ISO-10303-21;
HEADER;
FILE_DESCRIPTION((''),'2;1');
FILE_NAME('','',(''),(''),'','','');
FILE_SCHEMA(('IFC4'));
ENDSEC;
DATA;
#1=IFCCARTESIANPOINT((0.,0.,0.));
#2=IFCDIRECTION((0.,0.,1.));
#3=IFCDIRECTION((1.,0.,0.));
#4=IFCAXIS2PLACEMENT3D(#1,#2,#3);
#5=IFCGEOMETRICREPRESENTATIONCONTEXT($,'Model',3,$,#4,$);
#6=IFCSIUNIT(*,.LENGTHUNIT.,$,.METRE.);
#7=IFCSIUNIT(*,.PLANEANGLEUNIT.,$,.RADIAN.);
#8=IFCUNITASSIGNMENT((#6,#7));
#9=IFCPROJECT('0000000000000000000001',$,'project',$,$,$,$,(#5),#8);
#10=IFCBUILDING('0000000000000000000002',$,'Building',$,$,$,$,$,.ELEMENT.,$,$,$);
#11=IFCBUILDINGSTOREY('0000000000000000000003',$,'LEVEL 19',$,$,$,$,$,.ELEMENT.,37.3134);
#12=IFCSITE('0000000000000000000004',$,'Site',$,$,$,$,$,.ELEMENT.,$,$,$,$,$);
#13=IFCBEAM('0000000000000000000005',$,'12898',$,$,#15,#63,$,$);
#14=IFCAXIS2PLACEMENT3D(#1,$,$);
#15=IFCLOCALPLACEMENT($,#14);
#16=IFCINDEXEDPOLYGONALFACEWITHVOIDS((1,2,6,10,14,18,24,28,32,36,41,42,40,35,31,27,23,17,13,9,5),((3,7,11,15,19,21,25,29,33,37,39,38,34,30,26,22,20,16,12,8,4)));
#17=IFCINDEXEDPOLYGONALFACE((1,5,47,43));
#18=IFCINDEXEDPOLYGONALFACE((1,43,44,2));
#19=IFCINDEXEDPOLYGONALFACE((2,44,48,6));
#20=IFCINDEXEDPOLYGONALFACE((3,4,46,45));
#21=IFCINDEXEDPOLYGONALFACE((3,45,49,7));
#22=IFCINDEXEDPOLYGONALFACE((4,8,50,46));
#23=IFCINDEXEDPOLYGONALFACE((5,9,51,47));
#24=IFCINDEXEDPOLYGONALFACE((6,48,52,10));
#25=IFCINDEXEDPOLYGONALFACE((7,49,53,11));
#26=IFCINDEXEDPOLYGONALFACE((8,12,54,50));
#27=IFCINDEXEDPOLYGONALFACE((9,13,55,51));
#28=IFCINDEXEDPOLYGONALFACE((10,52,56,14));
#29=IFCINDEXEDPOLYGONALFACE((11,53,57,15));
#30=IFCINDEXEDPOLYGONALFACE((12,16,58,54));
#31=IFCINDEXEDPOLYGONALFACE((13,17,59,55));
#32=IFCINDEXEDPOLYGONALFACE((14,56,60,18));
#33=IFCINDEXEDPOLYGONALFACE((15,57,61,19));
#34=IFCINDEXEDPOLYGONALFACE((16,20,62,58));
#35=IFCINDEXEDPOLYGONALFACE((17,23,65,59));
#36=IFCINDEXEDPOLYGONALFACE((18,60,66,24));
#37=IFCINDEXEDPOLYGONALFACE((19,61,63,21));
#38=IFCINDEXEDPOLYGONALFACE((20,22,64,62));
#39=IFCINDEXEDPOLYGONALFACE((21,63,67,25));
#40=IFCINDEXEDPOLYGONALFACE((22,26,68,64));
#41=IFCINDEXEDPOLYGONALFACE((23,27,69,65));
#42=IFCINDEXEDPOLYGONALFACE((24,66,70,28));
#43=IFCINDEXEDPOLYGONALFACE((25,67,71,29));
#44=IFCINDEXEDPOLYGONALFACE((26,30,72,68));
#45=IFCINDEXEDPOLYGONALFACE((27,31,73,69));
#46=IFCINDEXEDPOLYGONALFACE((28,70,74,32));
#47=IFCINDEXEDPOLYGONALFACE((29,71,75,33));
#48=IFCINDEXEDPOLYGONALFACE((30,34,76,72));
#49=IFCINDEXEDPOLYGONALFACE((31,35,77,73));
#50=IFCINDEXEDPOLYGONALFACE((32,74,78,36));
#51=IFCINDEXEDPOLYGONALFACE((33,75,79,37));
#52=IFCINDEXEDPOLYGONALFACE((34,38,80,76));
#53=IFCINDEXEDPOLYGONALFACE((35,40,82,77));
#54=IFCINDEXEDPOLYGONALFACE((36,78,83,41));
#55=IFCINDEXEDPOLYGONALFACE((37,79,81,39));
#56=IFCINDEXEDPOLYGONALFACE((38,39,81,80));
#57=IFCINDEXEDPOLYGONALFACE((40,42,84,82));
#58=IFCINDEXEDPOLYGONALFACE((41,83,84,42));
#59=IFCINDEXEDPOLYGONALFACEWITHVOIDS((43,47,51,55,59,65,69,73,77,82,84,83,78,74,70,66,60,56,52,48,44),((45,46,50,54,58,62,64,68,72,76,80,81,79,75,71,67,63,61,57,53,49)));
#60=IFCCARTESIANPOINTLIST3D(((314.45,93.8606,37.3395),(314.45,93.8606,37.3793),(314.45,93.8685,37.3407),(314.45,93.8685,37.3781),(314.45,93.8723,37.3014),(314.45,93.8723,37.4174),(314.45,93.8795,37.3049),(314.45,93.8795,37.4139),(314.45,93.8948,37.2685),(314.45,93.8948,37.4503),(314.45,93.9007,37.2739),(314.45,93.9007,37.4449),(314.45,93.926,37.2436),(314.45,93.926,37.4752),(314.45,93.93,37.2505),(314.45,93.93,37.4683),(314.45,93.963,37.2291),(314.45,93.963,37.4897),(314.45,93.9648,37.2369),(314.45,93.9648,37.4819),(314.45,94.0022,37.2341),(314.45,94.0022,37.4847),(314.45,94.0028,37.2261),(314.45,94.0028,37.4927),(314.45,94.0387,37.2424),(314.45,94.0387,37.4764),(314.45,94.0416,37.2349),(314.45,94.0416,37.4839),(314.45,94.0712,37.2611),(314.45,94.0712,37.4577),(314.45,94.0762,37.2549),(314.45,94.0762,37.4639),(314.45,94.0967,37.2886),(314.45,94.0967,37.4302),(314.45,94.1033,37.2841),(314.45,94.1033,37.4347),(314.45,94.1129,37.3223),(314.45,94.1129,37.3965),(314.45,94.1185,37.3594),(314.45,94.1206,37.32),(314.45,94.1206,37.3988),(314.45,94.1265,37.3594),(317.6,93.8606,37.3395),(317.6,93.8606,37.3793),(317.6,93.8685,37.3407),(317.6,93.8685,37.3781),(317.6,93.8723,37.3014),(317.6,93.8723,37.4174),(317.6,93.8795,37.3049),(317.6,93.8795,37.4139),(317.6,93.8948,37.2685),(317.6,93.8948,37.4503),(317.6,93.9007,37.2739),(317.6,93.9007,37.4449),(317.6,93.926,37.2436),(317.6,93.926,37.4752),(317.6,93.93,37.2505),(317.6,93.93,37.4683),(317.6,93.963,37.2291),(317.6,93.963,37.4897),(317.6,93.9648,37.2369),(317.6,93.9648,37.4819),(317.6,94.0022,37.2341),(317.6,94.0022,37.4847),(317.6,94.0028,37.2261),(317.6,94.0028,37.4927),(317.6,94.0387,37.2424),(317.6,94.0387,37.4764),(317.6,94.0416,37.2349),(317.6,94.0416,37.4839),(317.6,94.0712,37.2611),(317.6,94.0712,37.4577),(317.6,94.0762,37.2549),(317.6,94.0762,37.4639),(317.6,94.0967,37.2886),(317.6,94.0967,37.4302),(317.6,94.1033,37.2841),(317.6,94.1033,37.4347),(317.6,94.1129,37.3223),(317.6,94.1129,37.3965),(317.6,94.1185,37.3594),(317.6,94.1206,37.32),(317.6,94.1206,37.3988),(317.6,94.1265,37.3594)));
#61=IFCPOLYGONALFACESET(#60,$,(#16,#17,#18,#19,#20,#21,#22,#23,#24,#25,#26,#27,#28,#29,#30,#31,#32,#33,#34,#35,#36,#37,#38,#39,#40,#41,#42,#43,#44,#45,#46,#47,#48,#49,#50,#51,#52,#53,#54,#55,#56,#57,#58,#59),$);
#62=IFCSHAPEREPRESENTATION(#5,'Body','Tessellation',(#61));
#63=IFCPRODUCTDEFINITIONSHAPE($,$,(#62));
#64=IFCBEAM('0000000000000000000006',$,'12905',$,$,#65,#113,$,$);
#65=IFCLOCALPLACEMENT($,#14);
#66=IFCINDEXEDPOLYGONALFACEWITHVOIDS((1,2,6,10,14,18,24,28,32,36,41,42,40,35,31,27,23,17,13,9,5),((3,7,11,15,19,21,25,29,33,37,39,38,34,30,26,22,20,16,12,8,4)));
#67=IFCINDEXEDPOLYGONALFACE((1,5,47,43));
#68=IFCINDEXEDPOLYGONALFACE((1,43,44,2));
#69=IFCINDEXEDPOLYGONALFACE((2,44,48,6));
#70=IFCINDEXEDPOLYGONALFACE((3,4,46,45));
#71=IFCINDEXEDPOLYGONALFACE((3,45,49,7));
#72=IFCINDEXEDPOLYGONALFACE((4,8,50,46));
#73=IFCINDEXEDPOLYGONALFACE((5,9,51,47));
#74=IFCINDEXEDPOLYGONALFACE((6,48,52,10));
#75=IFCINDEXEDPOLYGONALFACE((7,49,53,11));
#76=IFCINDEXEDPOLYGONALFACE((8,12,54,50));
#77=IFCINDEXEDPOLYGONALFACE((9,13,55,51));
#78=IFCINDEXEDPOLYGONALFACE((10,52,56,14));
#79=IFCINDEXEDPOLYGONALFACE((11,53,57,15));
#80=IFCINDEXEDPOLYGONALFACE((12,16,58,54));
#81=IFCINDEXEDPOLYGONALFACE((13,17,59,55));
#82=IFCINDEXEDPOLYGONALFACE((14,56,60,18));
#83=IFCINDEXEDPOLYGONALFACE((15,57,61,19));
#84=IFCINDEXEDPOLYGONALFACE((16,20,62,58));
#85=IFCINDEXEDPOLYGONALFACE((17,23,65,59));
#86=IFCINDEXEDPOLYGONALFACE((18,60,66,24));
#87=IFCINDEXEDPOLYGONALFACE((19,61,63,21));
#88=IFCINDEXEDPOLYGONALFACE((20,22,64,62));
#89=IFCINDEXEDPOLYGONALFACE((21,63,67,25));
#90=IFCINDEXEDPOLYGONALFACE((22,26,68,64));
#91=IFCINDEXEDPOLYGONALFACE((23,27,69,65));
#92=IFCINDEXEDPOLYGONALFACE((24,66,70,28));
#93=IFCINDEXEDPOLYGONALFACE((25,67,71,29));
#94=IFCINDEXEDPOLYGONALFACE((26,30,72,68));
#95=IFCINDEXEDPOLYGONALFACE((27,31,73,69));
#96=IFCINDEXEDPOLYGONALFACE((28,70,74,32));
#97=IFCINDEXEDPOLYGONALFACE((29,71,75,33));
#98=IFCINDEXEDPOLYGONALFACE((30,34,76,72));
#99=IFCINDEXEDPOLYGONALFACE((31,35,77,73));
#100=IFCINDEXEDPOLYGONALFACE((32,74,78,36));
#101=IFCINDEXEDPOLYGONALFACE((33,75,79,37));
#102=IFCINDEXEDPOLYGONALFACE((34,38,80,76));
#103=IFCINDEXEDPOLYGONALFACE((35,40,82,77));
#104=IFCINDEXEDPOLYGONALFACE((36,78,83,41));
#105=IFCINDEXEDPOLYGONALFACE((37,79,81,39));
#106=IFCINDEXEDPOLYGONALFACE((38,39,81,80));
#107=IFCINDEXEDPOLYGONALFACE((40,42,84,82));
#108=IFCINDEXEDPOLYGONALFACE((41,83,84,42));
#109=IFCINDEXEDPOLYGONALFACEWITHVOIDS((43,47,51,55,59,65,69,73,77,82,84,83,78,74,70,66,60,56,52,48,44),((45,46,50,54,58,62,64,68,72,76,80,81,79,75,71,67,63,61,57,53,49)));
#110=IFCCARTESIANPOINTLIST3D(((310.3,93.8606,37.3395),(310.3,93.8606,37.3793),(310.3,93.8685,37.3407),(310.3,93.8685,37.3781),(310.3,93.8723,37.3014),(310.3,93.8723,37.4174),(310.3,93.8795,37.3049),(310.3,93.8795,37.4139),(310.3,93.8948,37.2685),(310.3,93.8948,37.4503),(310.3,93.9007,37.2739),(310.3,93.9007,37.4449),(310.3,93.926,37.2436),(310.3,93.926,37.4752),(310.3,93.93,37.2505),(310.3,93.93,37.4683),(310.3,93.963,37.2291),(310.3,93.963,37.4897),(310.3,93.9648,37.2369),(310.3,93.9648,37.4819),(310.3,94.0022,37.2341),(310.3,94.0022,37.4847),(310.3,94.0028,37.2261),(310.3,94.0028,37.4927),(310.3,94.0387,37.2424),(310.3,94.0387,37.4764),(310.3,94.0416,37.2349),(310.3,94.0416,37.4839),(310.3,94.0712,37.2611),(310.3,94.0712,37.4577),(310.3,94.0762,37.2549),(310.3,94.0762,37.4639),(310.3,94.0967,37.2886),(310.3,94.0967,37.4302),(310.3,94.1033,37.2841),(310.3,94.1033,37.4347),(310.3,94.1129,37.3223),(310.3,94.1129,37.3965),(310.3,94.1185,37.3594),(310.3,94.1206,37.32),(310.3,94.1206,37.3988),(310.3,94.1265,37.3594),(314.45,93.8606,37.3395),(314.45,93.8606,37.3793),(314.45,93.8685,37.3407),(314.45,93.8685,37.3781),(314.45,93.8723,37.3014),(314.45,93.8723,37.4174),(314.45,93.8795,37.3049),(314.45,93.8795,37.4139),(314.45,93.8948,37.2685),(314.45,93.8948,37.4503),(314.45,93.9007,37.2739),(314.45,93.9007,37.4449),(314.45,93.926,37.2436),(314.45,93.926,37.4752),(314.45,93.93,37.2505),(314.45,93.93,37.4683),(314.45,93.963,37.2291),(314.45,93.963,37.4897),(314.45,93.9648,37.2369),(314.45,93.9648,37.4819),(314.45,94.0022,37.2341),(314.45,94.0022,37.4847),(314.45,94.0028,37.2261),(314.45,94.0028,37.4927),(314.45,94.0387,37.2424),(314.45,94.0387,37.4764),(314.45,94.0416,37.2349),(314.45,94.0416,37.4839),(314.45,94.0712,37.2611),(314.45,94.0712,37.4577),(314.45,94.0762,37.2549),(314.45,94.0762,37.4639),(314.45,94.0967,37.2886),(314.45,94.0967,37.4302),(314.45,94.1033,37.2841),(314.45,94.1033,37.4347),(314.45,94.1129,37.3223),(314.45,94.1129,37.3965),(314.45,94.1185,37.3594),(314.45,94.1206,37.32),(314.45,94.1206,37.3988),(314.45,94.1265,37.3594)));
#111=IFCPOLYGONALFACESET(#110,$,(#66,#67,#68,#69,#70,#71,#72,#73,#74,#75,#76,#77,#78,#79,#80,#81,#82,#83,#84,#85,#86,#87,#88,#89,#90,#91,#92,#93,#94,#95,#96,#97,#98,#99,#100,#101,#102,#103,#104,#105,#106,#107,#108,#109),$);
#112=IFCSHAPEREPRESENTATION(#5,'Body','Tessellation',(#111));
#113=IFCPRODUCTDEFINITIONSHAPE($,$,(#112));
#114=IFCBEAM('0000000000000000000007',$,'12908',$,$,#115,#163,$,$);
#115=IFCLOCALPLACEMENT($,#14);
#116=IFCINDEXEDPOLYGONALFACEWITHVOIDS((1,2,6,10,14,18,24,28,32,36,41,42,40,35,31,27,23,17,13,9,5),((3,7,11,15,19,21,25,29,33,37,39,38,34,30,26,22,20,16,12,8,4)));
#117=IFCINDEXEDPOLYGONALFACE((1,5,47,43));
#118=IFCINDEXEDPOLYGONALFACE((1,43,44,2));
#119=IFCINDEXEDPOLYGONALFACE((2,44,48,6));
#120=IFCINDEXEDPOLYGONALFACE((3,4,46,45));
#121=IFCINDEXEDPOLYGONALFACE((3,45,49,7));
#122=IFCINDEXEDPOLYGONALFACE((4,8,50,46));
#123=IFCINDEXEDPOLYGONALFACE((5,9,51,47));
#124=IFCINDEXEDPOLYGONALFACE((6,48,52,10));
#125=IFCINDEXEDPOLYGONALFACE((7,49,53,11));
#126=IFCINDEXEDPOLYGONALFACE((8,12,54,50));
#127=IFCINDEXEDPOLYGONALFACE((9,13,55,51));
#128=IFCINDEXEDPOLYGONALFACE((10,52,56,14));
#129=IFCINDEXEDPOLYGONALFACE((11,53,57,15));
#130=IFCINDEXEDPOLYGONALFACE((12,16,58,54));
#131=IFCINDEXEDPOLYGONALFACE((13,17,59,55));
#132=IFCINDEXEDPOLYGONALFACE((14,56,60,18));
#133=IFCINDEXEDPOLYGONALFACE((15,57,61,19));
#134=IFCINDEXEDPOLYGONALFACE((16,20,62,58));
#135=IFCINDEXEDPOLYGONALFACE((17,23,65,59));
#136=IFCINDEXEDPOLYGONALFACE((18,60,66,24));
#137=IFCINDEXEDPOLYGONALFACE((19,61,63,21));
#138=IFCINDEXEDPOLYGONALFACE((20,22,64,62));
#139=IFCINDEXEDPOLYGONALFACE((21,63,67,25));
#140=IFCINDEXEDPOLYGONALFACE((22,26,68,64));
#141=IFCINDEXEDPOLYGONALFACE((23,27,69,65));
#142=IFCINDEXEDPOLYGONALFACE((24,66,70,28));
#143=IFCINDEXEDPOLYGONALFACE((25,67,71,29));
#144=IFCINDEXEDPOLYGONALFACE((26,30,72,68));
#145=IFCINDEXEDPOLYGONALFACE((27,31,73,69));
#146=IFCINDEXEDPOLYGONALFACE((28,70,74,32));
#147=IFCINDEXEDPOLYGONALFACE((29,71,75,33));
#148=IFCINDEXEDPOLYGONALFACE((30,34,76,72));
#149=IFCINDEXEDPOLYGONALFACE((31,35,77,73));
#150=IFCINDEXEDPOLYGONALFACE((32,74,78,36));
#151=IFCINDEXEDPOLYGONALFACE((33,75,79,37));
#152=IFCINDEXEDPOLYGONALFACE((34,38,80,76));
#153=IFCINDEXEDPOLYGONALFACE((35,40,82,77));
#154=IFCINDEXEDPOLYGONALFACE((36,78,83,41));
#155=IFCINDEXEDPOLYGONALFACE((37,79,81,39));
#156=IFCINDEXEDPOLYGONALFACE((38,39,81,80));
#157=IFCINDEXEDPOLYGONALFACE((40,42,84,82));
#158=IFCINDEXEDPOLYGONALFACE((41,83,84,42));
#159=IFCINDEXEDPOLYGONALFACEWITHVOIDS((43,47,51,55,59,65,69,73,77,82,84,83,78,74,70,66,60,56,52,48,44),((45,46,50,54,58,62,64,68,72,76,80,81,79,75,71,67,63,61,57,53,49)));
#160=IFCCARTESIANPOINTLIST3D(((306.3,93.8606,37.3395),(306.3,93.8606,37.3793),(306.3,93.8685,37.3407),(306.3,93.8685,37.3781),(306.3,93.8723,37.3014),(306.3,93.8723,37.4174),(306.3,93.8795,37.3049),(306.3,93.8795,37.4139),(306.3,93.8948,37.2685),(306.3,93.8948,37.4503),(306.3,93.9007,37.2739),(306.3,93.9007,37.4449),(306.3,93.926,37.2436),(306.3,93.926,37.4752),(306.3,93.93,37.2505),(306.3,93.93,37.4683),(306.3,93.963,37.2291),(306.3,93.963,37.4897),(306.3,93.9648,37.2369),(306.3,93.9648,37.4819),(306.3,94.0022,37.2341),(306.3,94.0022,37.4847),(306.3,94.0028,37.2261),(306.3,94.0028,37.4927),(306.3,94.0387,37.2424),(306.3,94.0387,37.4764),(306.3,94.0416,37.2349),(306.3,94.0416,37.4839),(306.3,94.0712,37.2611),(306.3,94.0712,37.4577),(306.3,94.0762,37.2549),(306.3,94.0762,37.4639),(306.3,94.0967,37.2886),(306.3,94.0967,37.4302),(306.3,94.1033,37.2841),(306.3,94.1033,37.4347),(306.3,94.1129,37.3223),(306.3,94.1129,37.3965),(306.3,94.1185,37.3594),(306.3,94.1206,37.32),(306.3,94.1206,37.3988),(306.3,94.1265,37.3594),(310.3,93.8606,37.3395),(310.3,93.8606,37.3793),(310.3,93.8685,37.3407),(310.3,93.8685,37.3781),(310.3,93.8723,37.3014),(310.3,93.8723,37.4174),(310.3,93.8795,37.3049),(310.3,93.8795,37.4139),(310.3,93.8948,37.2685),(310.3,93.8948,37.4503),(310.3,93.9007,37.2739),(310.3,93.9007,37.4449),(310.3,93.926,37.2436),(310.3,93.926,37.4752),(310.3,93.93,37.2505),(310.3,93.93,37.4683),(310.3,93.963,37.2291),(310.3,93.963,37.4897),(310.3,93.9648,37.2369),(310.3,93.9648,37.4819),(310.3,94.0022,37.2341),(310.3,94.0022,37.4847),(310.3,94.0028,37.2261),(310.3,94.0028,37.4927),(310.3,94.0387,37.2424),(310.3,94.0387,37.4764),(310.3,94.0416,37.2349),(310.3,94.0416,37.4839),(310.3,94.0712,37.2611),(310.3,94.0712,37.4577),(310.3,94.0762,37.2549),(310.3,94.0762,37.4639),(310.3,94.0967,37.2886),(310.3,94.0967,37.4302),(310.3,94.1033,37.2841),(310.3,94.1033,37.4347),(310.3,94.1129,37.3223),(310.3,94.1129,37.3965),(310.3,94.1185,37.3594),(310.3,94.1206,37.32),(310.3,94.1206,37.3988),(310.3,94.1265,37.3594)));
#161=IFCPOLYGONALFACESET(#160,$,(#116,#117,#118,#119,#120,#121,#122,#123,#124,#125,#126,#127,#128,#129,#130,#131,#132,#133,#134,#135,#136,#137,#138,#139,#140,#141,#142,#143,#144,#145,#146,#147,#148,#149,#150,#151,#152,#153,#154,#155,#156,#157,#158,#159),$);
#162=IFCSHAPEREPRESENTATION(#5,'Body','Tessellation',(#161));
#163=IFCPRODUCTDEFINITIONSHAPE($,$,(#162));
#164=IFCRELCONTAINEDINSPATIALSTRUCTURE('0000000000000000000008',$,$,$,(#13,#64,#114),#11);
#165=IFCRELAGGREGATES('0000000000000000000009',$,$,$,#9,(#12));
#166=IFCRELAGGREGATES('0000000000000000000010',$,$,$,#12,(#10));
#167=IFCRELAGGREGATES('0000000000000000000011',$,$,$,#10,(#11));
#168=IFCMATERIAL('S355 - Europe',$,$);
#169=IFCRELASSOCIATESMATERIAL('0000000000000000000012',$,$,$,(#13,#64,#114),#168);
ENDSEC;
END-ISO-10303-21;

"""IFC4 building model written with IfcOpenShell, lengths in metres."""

from ifc_helpers import new_model, si_unit, frame, origin_with_axes, origin_2d_with_axis, place, context, project, spatial, hollow_circle, extrude, material, material_profile, profile_set, profile_usage, element, save


model = new_model("IFC4")

# Units and contexts
model_context = context("Model", 3, world=origin_with_axes())
ifc_project = project(units=[si_unit("LENGTHUNIT", "METRE"), si_unit("PLANEANGLEUNIT", "RADIAN")], contexts=[model_context])

# Site, building, storey
site = spatial("IfcSite", under=ifc_project, Name="Site", CompositionType="ELEMENT")
building = spatial("IfcBuilding", under=site, Name="Building", CompositionType="ELEMENT")
storey = spatial("IfcBuildingStorey", under=building, Name="LEVEL 19", CompositionType="ELEMENT", Elevation=37.3134)

# Beams
ifc_material = material(Name="S355 - Europe")
ifc_material_profile_1 = material_profile(ifc_material, hollow_circle(Radius=0.1337, WallThickness=0.008, at=origin_2d_with_axis()))
ifc_profile_set_1 = profile_set([ifc_material_profile_1])
ifc_profile_usage_1 = profile_usage(ifc_profile_set_1, cardinal=10)
beam_1_placement = place(None, frame((314.45, 93.9928, 37.3594), z_axis=(1.0, 0.0, 0.0), x_axis=(0.0, 1.0, 0.0)))
element("IfcBeam", 1, at=beam_1_placement, inside=storey, material=ifc_profile_usage_1, Name="12898", context=model_context, shape_type="SweptSolid", body=[
    extrude(hollow_circle(Radius=0.1337, WallThickness=0.008, at=origin_2d_with_axis()), origin_with_axes(), (0.0, 0.0, 1.0), 3.15),
])
ifc_material_profile_2 = material_profile(ifc_material, hollow_circle(Radius=0.1337, WallThickness=0.008, at=origin_2d_with_axis()))
ifc_profile_set_2 = profile_set([ifc_material_profile_2])
ifc_profile_usage_2 = profile_usage(ifc_profile_set_2, cardinal=10)
beam_2_placement = place(None, frame((310.3, 93.9928, 37.3594), z_axis=(1.0, 0.0, 0.0), x_axis=(0.0, 1.0, 0.0)))
element("IfcBeam", 2, at=beam_2_placement, inside=storey, material=ifc_profile_usage_2, Name="12905", context=model_context, shape_type="SweptSolid", body=[
    extrude(hollow_circle(Radius=0.1337, WallThickness=0.008, at=origin_2d_with_axis()), origin_with_axes(), (0.0, 0.0, 1.0), 4.15),
])
ifc_material_profile_3 = material_profile(ifc_material, hollow_circle(Radius=0.1337, WallThickness=0.008, at=origin_2d_with_axis()))
ifc_profile_set_3 = profile_set([ifc_material_profile_3])
ifc_profile_usage_3 = profile_usage(ifc_profile_set_3, cardinal=10)
beam_3_placement = place(None, frame((306.3, 93.9928, 37.3594), z_axis=(1.0, 0.0, 0.0), x_axis=(0.0, 1.0, 0.0)))
element("IfcBeam", 3, at=beam_3_placement, inside=storey, material=ifc_profile_usage_3, Name="12908", context=model_context, shape_type="SweptSolid", body=[
    extrude(hollow_circle(Radius=0.1337, WallThickness=0.008, at=origin_2d_with_axis()), origin_with_axes(), (0.0, 0.0, 1.0), 4.0),
])

save(model, "model.ifc")
